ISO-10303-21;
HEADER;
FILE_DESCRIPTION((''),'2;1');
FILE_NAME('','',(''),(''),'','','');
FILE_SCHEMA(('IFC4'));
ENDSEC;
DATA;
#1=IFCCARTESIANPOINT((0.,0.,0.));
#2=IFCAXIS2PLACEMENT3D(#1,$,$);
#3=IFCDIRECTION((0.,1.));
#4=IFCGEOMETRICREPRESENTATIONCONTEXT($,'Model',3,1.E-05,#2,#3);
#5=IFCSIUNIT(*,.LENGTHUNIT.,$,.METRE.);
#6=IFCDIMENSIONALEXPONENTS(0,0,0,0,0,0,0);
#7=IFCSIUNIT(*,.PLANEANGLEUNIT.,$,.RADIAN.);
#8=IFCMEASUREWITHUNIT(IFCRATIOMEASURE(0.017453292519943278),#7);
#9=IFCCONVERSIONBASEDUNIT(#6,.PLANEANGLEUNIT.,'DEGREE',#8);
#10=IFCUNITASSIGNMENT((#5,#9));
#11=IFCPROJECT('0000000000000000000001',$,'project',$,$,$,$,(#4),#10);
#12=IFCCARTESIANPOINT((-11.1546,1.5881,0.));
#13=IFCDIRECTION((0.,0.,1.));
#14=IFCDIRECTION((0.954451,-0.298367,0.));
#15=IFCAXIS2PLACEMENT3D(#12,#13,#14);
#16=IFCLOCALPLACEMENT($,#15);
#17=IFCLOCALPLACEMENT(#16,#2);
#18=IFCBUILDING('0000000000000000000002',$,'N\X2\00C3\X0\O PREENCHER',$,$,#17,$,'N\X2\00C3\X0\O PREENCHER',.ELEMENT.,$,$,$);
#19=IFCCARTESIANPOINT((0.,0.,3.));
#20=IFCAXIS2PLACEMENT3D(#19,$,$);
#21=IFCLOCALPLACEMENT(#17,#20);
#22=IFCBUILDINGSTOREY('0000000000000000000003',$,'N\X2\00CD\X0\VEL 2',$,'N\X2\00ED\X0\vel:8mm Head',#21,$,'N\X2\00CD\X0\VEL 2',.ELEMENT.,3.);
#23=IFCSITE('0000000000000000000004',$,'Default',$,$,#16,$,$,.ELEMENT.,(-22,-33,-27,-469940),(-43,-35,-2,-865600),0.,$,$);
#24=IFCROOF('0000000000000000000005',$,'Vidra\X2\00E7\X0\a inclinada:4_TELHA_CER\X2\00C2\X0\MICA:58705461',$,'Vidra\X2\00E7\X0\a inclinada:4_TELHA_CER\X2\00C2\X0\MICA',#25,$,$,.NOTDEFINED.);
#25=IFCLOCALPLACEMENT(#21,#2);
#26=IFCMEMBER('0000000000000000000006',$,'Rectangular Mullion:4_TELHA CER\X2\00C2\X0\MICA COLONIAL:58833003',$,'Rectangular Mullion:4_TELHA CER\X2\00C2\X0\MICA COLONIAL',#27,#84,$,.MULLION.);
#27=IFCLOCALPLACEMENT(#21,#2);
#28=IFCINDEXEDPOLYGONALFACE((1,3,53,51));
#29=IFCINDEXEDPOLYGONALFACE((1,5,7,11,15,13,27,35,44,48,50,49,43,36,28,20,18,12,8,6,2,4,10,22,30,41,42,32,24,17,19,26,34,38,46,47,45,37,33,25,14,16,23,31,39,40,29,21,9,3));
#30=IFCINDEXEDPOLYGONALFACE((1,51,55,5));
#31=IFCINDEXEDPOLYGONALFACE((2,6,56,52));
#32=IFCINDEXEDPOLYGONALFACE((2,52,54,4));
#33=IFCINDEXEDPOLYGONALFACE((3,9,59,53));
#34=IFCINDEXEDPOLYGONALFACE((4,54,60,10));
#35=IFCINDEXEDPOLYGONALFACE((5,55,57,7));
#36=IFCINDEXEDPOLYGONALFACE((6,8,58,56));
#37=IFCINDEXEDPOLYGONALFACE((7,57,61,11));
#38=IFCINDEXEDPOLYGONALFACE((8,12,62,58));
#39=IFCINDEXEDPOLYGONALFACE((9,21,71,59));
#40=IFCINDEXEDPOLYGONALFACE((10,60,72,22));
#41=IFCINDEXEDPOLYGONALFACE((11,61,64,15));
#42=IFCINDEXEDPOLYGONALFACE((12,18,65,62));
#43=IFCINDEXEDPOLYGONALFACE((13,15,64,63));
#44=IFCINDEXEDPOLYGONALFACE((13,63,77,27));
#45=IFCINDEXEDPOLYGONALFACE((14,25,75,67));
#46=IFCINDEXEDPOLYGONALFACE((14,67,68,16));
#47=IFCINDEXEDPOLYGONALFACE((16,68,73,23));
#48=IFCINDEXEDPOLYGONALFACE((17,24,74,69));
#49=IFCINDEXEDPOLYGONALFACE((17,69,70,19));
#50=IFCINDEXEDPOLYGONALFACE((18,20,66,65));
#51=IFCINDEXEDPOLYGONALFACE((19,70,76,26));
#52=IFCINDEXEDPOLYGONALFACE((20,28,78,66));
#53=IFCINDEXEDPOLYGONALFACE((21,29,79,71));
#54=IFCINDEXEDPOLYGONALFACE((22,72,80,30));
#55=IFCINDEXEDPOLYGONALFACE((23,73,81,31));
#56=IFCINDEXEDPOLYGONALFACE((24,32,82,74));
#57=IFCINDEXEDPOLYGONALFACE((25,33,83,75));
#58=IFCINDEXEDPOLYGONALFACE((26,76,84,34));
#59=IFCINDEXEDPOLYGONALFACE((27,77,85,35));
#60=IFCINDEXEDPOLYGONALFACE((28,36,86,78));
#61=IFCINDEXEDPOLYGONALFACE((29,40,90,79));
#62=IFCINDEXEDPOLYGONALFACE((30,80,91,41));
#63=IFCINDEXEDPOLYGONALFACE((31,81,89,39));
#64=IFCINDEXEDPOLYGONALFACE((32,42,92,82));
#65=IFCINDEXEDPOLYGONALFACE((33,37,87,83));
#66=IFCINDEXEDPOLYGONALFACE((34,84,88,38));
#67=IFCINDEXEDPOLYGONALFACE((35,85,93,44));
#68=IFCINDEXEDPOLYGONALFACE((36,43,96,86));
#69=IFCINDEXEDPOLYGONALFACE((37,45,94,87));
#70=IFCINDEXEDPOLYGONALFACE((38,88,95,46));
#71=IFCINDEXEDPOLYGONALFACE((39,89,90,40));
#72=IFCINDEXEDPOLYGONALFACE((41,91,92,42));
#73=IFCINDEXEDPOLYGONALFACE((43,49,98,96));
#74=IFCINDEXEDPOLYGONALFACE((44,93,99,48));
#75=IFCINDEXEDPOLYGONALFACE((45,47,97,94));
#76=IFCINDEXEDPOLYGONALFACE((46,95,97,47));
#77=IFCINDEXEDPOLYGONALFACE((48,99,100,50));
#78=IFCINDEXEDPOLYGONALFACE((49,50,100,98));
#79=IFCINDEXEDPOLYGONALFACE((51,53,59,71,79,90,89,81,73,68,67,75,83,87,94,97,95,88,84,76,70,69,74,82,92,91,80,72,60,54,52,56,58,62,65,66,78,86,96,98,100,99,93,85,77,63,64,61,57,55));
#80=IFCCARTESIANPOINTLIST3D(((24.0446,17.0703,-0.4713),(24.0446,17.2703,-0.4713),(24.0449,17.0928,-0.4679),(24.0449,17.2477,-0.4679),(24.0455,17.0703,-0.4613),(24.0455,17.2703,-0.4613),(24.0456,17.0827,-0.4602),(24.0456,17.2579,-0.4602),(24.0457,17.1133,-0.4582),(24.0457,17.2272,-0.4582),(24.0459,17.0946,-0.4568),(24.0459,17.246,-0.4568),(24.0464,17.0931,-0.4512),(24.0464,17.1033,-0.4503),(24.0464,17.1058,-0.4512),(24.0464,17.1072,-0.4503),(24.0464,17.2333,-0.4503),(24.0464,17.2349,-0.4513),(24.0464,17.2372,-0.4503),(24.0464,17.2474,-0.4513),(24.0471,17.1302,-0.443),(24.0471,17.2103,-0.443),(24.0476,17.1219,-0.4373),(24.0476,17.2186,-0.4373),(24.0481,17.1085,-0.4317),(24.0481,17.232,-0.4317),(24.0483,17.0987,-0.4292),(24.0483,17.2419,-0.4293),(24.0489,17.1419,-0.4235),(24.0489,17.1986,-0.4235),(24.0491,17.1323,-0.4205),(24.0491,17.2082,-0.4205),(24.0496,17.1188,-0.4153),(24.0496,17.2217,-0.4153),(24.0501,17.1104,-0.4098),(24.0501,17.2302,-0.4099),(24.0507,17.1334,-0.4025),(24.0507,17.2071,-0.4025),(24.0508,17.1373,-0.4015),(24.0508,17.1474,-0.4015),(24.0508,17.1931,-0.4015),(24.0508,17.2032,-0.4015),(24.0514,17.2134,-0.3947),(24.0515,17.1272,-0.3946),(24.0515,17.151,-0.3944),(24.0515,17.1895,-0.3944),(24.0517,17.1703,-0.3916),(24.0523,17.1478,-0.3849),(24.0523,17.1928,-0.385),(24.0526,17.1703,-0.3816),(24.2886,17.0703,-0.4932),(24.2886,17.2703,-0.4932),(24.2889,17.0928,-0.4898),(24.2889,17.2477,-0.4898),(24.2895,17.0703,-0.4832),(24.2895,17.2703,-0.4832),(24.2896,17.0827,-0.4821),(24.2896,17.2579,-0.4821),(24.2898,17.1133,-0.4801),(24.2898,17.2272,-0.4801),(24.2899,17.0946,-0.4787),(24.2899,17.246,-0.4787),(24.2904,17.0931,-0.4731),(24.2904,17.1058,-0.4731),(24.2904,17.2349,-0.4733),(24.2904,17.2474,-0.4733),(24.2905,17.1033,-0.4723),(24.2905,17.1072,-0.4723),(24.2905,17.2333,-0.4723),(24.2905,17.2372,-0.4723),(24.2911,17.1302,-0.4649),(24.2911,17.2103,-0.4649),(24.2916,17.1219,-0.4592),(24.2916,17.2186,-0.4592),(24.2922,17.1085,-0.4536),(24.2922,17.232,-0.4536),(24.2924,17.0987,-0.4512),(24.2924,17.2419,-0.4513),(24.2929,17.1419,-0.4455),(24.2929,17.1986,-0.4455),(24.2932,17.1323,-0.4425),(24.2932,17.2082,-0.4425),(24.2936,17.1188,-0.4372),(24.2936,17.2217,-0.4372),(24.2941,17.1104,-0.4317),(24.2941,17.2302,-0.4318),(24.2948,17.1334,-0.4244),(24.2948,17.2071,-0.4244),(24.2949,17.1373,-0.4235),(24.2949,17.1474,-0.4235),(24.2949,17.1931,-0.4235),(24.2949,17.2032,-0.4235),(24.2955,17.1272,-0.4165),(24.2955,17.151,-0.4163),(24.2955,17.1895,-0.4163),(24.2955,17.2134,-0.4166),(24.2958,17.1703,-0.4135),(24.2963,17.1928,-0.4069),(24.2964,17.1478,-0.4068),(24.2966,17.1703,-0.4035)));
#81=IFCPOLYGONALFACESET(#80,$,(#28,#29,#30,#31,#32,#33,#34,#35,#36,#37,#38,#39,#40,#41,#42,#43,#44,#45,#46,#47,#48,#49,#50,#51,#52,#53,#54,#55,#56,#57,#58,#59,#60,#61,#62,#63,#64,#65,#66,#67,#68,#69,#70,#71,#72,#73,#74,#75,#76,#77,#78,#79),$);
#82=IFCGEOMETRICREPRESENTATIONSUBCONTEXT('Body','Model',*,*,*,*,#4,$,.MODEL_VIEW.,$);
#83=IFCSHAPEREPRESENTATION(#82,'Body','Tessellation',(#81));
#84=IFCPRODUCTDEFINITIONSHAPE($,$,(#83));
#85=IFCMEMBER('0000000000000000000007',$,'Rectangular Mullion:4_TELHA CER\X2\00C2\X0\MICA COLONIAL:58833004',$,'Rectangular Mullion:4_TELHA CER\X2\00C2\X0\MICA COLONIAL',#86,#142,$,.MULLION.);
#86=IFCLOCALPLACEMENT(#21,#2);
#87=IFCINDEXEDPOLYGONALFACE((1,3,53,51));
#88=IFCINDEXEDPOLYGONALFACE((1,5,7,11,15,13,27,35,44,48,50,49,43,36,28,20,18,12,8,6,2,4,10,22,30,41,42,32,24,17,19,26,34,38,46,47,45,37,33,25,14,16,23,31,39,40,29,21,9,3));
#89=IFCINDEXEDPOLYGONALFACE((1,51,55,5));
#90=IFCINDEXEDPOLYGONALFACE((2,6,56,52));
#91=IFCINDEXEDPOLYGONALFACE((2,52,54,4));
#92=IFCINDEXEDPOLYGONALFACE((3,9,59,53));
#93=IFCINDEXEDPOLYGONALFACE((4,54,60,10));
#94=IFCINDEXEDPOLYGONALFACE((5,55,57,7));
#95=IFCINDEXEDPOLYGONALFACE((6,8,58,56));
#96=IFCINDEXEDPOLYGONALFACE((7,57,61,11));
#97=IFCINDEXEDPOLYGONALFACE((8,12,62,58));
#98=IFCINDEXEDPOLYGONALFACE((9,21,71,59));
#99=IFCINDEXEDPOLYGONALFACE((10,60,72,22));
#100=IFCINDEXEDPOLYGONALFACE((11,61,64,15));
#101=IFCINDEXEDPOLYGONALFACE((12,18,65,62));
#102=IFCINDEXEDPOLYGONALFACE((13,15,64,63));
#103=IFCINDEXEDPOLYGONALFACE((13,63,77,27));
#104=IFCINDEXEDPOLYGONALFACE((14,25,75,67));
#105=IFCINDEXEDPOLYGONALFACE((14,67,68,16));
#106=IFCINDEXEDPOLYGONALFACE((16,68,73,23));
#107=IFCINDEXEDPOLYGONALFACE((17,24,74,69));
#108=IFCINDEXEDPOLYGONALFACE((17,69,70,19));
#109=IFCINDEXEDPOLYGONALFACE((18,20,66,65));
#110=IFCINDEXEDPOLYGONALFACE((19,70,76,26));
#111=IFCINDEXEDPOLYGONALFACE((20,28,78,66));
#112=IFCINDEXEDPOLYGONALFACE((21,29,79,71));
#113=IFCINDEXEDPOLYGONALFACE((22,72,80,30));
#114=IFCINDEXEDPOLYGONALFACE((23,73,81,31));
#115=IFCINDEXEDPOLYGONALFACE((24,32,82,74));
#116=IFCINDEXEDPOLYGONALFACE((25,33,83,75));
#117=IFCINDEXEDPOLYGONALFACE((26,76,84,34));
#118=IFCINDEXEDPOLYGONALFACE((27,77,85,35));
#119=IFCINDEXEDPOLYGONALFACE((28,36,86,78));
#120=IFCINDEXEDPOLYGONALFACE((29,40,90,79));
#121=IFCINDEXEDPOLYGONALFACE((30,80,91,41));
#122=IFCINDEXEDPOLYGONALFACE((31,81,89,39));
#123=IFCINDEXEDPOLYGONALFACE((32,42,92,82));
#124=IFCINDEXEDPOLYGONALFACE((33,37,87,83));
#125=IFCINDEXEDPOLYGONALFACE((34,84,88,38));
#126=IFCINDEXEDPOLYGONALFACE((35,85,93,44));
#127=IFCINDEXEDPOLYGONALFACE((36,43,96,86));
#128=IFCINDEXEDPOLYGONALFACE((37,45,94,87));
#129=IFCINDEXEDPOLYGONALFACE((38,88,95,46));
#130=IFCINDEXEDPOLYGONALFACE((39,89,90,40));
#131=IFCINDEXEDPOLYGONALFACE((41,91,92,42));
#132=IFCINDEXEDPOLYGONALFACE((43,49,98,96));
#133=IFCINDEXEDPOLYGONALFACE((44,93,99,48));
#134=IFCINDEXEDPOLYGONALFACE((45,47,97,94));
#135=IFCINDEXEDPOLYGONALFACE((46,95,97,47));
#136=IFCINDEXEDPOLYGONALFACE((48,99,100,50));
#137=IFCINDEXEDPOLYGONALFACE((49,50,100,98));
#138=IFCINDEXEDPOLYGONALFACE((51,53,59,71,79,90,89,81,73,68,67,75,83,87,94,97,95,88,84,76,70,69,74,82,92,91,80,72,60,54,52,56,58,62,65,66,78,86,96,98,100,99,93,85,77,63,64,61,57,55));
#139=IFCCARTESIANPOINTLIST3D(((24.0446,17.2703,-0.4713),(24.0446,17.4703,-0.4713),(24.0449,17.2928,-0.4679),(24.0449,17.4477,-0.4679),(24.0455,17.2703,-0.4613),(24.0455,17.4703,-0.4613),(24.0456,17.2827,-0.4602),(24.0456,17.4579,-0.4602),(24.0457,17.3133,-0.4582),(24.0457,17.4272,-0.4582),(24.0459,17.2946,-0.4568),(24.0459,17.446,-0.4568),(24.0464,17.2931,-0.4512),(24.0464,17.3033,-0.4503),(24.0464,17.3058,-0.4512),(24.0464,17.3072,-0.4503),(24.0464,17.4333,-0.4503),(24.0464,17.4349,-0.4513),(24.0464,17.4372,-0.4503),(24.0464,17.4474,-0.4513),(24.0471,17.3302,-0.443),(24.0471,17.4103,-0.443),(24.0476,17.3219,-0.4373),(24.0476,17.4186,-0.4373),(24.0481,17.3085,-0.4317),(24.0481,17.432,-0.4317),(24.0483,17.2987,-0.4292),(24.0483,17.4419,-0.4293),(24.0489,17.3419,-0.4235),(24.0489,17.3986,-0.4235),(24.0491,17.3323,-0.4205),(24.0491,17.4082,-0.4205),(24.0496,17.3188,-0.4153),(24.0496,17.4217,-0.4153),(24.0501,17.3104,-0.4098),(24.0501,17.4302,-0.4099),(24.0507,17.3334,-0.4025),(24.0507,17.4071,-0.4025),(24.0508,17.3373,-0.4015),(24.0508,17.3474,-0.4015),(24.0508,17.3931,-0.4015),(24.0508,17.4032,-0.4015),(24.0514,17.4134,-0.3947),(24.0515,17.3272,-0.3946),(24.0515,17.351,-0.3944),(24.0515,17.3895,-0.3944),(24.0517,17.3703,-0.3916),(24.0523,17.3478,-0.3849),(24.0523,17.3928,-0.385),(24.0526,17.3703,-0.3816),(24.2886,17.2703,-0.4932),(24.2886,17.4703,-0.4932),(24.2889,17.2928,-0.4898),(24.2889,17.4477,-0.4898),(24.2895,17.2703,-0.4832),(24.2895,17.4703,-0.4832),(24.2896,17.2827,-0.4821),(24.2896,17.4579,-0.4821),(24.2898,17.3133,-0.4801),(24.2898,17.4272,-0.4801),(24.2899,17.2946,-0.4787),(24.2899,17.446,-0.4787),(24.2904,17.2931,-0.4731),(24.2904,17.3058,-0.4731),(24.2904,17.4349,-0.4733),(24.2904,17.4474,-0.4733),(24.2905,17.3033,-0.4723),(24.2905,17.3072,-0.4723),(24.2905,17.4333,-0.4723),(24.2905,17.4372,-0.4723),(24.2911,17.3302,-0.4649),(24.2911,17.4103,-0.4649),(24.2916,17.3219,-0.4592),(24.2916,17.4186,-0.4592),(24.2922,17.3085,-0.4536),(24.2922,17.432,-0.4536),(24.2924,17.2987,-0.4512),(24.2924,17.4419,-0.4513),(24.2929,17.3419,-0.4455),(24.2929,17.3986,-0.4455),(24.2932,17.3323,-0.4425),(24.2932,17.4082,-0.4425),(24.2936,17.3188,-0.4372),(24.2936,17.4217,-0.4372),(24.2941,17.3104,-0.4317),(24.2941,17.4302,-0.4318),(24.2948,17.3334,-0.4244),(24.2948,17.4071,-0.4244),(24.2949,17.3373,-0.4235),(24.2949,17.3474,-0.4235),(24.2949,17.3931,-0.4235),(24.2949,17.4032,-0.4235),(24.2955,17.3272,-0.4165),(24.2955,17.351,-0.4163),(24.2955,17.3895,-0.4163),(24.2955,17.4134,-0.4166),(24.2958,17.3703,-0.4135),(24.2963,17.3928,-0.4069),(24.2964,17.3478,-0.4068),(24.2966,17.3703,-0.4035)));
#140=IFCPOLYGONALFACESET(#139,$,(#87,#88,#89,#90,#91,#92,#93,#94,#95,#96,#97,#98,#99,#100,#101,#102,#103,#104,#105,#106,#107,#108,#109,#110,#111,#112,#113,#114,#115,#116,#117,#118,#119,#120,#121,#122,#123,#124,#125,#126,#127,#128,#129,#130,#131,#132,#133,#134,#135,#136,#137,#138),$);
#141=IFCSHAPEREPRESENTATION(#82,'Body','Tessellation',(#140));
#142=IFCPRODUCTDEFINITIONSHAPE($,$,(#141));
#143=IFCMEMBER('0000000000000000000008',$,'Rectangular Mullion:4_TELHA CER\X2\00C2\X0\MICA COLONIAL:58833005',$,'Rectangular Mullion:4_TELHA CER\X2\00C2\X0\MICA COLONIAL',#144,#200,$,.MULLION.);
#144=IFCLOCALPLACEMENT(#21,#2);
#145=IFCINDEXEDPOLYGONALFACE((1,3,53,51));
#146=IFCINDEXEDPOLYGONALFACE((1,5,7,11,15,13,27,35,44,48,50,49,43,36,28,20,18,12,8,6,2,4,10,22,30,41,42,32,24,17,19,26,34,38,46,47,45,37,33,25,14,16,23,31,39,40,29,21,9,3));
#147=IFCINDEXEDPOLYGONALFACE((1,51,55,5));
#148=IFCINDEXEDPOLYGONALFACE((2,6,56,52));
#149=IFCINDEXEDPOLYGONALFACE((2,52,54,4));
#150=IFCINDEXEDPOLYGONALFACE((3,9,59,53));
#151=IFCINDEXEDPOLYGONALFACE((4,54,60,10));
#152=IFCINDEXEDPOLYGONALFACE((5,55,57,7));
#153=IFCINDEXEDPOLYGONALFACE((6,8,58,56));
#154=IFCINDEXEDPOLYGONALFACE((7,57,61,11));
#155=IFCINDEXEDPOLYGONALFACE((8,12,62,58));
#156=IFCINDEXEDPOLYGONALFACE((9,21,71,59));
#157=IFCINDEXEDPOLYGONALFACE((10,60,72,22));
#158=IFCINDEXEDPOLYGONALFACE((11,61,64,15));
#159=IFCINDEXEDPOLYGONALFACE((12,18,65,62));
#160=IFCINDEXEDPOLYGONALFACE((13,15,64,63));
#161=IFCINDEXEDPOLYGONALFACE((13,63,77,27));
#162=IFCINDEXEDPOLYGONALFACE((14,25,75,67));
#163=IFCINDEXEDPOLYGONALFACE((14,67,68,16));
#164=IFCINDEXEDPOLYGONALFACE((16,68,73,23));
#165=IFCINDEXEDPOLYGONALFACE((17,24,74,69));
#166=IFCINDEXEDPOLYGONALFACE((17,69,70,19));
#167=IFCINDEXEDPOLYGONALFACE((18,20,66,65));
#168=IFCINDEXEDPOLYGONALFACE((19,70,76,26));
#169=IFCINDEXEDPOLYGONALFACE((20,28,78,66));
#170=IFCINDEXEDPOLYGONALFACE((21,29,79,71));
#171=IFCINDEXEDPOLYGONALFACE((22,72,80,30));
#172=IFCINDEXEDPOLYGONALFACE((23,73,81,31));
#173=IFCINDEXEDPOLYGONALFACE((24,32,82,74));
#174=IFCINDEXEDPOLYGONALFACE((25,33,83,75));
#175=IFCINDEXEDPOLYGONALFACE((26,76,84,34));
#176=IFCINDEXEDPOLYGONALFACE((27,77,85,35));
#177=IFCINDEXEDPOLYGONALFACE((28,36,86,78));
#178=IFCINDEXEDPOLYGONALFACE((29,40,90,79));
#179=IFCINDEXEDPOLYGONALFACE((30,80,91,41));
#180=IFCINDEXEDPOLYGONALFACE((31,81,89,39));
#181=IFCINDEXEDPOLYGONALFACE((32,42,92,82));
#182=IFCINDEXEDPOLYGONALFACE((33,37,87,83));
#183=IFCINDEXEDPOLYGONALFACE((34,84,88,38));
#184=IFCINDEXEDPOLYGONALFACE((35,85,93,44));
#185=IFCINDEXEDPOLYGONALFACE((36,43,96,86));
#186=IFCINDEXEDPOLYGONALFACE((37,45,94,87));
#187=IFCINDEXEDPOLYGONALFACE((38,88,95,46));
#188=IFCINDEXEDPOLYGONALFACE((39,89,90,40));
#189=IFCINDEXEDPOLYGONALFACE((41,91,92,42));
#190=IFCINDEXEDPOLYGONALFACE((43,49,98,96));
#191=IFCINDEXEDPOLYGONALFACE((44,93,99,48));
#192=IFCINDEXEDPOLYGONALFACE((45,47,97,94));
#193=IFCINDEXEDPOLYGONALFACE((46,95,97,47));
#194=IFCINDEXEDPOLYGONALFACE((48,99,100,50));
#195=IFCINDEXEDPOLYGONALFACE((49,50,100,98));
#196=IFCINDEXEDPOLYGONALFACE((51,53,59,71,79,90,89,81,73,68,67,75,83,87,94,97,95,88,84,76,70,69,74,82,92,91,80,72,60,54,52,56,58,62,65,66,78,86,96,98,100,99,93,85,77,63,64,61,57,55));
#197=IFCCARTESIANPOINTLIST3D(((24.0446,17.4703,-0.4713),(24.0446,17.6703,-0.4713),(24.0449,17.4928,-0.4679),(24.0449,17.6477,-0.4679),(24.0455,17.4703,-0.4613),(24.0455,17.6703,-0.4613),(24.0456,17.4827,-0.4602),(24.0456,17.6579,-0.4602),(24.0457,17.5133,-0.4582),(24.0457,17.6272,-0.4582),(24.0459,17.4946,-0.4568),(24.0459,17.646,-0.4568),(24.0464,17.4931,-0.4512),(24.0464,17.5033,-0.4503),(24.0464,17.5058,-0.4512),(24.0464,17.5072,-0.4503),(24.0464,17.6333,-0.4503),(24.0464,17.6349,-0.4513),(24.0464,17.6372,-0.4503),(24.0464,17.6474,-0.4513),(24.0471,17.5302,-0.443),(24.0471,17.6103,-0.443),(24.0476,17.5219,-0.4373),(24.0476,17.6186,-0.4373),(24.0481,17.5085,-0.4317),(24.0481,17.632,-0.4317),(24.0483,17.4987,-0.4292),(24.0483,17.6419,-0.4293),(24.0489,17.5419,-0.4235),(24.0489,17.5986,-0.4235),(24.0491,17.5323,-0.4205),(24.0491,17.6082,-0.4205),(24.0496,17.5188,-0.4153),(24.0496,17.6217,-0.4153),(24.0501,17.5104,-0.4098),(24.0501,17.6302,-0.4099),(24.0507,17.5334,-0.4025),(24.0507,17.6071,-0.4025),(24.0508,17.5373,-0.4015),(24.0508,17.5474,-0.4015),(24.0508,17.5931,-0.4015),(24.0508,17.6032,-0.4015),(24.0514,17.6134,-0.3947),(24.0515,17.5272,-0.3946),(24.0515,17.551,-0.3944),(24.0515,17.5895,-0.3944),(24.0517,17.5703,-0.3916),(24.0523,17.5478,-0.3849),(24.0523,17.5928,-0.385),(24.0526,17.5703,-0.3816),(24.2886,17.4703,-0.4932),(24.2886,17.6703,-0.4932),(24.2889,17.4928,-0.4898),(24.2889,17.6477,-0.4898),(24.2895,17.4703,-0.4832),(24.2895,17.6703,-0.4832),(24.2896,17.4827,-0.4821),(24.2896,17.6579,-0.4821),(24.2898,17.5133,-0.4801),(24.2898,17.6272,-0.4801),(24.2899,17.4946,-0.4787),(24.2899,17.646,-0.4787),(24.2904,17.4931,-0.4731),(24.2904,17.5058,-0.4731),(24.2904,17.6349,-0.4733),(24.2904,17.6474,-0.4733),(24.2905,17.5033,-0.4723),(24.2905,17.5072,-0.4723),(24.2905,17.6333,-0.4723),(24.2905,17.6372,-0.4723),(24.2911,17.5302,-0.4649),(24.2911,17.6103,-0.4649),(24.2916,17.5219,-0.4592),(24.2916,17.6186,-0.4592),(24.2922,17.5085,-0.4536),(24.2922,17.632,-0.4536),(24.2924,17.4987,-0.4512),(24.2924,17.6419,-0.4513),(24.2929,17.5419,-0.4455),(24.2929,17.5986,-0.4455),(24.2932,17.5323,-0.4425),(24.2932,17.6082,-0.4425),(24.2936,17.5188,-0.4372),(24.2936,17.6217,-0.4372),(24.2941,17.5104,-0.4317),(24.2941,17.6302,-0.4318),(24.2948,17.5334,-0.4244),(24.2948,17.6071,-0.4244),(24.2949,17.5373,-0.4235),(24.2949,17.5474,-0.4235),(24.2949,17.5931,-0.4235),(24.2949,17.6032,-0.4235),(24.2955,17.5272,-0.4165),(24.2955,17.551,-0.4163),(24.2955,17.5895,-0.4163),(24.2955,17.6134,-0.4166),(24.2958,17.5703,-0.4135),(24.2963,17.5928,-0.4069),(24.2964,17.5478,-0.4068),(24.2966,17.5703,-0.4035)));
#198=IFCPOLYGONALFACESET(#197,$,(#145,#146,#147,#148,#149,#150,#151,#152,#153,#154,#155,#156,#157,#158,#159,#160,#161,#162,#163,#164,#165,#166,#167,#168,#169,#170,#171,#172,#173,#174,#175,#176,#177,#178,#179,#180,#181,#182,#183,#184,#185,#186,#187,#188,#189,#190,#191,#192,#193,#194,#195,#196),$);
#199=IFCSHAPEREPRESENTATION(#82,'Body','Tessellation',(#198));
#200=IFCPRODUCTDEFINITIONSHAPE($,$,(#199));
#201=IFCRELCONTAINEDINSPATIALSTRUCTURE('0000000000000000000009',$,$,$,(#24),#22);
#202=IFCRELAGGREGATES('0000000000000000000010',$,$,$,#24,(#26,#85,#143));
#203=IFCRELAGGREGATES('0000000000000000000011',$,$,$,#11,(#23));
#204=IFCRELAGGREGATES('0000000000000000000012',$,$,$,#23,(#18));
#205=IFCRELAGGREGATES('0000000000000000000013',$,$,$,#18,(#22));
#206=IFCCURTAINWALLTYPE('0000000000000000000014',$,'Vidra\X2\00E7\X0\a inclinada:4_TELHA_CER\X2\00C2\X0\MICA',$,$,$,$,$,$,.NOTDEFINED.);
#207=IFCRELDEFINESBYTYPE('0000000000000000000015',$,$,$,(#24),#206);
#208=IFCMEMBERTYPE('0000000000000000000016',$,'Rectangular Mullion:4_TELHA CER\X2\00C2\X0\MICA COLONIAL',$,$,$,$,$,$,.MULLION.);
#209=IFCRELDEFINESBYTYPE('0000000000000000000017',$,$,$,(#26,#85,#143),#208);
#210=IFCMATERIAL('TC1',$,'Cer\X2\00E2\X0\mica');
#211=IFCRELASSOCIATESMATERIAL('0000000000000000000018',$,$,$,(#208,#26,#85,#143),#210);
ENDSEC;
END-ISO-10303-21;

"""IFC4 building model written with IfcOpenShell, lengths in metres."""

from ifc_helpers import new_model, entity, si_unit, converted_unit, direction, frame, origin, place, context, subcontext, project, spatial, line, arc, indexed_curve, outline, extrude, source, transform, mapped, material, type_object, type_shapes, element, aggregate, save


model = new_model("IFC4")

# Units and contexts
model_context = context("Model", 3, precision=1e-05, world=origin(), true_north=direction((0.0, 1.0)))
body_context = subcontext(model_context, "Body", "Model", "MODEL_VIEW")
ifc_project = project(units=[si_unit("LENGTHUNIT", "METRE"), converted_unit("PLANEANGLEUNIT", "DEGREE", entity("IfcRatioMeasure", 0.017453292519943278), si_unit("PLANEANGLEUNIT", "RADIAN"), dimensions=[0, 0, 0, 0, 0, 0, 0])], contexts=[model_context])

# Site, building, storey
site_placement = place(None, frame((-11.1546, 1.5881, 0.0), z_axis=(0.0, 0.0, 1.0), x_axis=(0.954451, -0.298367, 0.0)))
site = spatial("IfcSite", under=ifc_project, at=site_placement, Name="Default", CompositionType="ELEMENT", RefLatitude=(-22, -33, -27, -469940), RefLongitude=(-43, -35, -2, -865600), RefElevation=0.0)
building_placement = place(site_placement, origin())
building = spatial("IfcBuilding", under=site, at=building_placement, Name="NÃO PREENCHER", LongName="NÃO PREENCHER", CompositionType="ELEMENT")
storey_placement = place(building_placement, frame((0.0, 0.0, 3.0)))
storey = spatial("IfcBuildingStorey", under=building, at=storey_placement, Name="NÍVEL 2", ObjectType="Nível:8mm Head", LongName="NÍVEL 2", CompositionType="ELEMENT", Elevation=3.0)

# Roof, members
curtain_wall_type = type_object("IfcCurtainWallType", Name="Vidraça inclinada:4_TELHA_CERÂMICA", PredefinedType="NOTDEFINED")
roof_placement = place(storey_placement, frame((0.0, 0.0, -3.0)))
roof = element("IfcRoof", 1, at=roof_placement, inside=storey, type_object=curtain_wall_type, Name="Vidraça inclinada:4_TELHA_CERÂMICA:58705461", ObjectType="Vidraça inclinada:4_TELHA_CERÂMICA", PredefinedType="NOTDEFINED")
ifc_material_1 = material(Name="TC1", Category="Cerâmica")
member_type_1 = type_object("IfcMemberType", Name="Rectangular Mullion:4_TELHA CERÂMICA COLONIAL", PredefinedType="MULLION", material=ifc_material_1)
shared_shape_1 = source(origin(), body_context, "Body", "SweptSolid", [
    extrude(outline(indexed_curve([(-0.029, -0.1), (-0.019, -0.1), (-0.0164, -0.0815), (-0.0089, -0.0645), (-0.0089, -0.0771), (0.061, 0.0), (-0.009, 0.0771), (-0.009, 0.0646), (-0.0165, 0.0816), (-0.019, 0.1), (-0.029, 0.1), (-0.0089, 0.0479), (0.041, 0.0229), (0.041, 0.0329), (0.0131, 0.0425), (-0.008, 0.0631), (-0.008, 0.067), (0.051, 0.0), (-0.008, -0.067), (-0.008, -0.0631), (0.0131, -0.0425), (0.041, -0.0329), (0.041, -0.0229), (-0.0089, -0.0479)], segments=[line(1, 2), arc(2, 3, 4), line(4, 5), arc(5, 6, 7), line(7, 8), arc(8, 9, 10), line(10, 11), arc(11, 12, 13), line(13, 14), arc(14, 15, 16), line(16, 17), arc(17, 18, 19), line(19, 20), arc(20, 21, 22), line(22, 23), arc(23, 24, 1)], self_intersect=False)), frame((0.0, -0.029, -0.245), z_axis=(0.0, 0.0, 1.0), x_axis=(0.0, -1.0, 0.0)), (0.0, 0.0, 1.0), 0.245),
])
type_shapes(member_type_1, [shared_shape_1])
member_1_placement = place(roof_placement, frame((24.0446, 17.1703, 2.5287), z_axis=(-0.99599, 0.0, 0.089469), x_axis=(0.0, 1.0, 0.0)))
member_1 = element("IfcMember", 2, at=member_1_placement, type_object=member_type_1, material=ifc_material_1, Name="Rectangular Mullion:4_TELHA CERÂMICA COLONIAL:58833003", ObjectType="Rectangular Mullion:4_TELHA CERÂMICA COLONIAL", PredefinedType="MULLION", context=body_context, shape_type="MappedRepresentation", body=[
    mapped(shared_shape_1, transform((0.0, 0.0, 0.0), scale=1.0)),
])
member_2_placement = place(roof_placement, frame((24.0446, 17.3703, 2.5287), z_axis=(-0.99599, 0.0, 0.089469), x_axis=(0.0, 1.0, 0.0)))
member_2 = element("IfcMember", 3, at=member_2_placement, type_object=member_type_1, material=ifc_material_1, Name="Rectangular Mullion:4_TELHA CERÂMICA COLONIAL:58833004", ObjectType="Rectangular Mullion:4_TELHA CERÂMICA COLONIAL", PredefinedType="MULLION", context=body_context, shape_type="MappedRepresentation", body=[
    mapped(shared_shape_1, transform((0.0, 0.0, 0.0), scale=1.0)),
])
member_3_placement = place(roof_placement, frame((24.0446, 17.5703, 2.5287), z_axis=(-0.99599, 0.0, 0.089469), x_axis=(0.0, 1.0, 0.0)))
member_3 = element("IfcMember", 4, at=member_3_placement, type_object=member_type_1, material=ifc_material_1, Name="Rectangular Mullion:4_TELHA CERÂMICA COLONIAL:58833005", ObjectType="Rectangular Mullion:4_TELHA CERÂMICA COLONIAL", PredefinedType="MULLION", context=body_context, shape_type="MappedRepresentation", body=[
    mapped(shared_shape_1, transform((0.0, 0.0, 0.0), scale=1.0)),
])
aggregate(roof, [member_1, member_2, member_3])

save(model, "model.ifc")
